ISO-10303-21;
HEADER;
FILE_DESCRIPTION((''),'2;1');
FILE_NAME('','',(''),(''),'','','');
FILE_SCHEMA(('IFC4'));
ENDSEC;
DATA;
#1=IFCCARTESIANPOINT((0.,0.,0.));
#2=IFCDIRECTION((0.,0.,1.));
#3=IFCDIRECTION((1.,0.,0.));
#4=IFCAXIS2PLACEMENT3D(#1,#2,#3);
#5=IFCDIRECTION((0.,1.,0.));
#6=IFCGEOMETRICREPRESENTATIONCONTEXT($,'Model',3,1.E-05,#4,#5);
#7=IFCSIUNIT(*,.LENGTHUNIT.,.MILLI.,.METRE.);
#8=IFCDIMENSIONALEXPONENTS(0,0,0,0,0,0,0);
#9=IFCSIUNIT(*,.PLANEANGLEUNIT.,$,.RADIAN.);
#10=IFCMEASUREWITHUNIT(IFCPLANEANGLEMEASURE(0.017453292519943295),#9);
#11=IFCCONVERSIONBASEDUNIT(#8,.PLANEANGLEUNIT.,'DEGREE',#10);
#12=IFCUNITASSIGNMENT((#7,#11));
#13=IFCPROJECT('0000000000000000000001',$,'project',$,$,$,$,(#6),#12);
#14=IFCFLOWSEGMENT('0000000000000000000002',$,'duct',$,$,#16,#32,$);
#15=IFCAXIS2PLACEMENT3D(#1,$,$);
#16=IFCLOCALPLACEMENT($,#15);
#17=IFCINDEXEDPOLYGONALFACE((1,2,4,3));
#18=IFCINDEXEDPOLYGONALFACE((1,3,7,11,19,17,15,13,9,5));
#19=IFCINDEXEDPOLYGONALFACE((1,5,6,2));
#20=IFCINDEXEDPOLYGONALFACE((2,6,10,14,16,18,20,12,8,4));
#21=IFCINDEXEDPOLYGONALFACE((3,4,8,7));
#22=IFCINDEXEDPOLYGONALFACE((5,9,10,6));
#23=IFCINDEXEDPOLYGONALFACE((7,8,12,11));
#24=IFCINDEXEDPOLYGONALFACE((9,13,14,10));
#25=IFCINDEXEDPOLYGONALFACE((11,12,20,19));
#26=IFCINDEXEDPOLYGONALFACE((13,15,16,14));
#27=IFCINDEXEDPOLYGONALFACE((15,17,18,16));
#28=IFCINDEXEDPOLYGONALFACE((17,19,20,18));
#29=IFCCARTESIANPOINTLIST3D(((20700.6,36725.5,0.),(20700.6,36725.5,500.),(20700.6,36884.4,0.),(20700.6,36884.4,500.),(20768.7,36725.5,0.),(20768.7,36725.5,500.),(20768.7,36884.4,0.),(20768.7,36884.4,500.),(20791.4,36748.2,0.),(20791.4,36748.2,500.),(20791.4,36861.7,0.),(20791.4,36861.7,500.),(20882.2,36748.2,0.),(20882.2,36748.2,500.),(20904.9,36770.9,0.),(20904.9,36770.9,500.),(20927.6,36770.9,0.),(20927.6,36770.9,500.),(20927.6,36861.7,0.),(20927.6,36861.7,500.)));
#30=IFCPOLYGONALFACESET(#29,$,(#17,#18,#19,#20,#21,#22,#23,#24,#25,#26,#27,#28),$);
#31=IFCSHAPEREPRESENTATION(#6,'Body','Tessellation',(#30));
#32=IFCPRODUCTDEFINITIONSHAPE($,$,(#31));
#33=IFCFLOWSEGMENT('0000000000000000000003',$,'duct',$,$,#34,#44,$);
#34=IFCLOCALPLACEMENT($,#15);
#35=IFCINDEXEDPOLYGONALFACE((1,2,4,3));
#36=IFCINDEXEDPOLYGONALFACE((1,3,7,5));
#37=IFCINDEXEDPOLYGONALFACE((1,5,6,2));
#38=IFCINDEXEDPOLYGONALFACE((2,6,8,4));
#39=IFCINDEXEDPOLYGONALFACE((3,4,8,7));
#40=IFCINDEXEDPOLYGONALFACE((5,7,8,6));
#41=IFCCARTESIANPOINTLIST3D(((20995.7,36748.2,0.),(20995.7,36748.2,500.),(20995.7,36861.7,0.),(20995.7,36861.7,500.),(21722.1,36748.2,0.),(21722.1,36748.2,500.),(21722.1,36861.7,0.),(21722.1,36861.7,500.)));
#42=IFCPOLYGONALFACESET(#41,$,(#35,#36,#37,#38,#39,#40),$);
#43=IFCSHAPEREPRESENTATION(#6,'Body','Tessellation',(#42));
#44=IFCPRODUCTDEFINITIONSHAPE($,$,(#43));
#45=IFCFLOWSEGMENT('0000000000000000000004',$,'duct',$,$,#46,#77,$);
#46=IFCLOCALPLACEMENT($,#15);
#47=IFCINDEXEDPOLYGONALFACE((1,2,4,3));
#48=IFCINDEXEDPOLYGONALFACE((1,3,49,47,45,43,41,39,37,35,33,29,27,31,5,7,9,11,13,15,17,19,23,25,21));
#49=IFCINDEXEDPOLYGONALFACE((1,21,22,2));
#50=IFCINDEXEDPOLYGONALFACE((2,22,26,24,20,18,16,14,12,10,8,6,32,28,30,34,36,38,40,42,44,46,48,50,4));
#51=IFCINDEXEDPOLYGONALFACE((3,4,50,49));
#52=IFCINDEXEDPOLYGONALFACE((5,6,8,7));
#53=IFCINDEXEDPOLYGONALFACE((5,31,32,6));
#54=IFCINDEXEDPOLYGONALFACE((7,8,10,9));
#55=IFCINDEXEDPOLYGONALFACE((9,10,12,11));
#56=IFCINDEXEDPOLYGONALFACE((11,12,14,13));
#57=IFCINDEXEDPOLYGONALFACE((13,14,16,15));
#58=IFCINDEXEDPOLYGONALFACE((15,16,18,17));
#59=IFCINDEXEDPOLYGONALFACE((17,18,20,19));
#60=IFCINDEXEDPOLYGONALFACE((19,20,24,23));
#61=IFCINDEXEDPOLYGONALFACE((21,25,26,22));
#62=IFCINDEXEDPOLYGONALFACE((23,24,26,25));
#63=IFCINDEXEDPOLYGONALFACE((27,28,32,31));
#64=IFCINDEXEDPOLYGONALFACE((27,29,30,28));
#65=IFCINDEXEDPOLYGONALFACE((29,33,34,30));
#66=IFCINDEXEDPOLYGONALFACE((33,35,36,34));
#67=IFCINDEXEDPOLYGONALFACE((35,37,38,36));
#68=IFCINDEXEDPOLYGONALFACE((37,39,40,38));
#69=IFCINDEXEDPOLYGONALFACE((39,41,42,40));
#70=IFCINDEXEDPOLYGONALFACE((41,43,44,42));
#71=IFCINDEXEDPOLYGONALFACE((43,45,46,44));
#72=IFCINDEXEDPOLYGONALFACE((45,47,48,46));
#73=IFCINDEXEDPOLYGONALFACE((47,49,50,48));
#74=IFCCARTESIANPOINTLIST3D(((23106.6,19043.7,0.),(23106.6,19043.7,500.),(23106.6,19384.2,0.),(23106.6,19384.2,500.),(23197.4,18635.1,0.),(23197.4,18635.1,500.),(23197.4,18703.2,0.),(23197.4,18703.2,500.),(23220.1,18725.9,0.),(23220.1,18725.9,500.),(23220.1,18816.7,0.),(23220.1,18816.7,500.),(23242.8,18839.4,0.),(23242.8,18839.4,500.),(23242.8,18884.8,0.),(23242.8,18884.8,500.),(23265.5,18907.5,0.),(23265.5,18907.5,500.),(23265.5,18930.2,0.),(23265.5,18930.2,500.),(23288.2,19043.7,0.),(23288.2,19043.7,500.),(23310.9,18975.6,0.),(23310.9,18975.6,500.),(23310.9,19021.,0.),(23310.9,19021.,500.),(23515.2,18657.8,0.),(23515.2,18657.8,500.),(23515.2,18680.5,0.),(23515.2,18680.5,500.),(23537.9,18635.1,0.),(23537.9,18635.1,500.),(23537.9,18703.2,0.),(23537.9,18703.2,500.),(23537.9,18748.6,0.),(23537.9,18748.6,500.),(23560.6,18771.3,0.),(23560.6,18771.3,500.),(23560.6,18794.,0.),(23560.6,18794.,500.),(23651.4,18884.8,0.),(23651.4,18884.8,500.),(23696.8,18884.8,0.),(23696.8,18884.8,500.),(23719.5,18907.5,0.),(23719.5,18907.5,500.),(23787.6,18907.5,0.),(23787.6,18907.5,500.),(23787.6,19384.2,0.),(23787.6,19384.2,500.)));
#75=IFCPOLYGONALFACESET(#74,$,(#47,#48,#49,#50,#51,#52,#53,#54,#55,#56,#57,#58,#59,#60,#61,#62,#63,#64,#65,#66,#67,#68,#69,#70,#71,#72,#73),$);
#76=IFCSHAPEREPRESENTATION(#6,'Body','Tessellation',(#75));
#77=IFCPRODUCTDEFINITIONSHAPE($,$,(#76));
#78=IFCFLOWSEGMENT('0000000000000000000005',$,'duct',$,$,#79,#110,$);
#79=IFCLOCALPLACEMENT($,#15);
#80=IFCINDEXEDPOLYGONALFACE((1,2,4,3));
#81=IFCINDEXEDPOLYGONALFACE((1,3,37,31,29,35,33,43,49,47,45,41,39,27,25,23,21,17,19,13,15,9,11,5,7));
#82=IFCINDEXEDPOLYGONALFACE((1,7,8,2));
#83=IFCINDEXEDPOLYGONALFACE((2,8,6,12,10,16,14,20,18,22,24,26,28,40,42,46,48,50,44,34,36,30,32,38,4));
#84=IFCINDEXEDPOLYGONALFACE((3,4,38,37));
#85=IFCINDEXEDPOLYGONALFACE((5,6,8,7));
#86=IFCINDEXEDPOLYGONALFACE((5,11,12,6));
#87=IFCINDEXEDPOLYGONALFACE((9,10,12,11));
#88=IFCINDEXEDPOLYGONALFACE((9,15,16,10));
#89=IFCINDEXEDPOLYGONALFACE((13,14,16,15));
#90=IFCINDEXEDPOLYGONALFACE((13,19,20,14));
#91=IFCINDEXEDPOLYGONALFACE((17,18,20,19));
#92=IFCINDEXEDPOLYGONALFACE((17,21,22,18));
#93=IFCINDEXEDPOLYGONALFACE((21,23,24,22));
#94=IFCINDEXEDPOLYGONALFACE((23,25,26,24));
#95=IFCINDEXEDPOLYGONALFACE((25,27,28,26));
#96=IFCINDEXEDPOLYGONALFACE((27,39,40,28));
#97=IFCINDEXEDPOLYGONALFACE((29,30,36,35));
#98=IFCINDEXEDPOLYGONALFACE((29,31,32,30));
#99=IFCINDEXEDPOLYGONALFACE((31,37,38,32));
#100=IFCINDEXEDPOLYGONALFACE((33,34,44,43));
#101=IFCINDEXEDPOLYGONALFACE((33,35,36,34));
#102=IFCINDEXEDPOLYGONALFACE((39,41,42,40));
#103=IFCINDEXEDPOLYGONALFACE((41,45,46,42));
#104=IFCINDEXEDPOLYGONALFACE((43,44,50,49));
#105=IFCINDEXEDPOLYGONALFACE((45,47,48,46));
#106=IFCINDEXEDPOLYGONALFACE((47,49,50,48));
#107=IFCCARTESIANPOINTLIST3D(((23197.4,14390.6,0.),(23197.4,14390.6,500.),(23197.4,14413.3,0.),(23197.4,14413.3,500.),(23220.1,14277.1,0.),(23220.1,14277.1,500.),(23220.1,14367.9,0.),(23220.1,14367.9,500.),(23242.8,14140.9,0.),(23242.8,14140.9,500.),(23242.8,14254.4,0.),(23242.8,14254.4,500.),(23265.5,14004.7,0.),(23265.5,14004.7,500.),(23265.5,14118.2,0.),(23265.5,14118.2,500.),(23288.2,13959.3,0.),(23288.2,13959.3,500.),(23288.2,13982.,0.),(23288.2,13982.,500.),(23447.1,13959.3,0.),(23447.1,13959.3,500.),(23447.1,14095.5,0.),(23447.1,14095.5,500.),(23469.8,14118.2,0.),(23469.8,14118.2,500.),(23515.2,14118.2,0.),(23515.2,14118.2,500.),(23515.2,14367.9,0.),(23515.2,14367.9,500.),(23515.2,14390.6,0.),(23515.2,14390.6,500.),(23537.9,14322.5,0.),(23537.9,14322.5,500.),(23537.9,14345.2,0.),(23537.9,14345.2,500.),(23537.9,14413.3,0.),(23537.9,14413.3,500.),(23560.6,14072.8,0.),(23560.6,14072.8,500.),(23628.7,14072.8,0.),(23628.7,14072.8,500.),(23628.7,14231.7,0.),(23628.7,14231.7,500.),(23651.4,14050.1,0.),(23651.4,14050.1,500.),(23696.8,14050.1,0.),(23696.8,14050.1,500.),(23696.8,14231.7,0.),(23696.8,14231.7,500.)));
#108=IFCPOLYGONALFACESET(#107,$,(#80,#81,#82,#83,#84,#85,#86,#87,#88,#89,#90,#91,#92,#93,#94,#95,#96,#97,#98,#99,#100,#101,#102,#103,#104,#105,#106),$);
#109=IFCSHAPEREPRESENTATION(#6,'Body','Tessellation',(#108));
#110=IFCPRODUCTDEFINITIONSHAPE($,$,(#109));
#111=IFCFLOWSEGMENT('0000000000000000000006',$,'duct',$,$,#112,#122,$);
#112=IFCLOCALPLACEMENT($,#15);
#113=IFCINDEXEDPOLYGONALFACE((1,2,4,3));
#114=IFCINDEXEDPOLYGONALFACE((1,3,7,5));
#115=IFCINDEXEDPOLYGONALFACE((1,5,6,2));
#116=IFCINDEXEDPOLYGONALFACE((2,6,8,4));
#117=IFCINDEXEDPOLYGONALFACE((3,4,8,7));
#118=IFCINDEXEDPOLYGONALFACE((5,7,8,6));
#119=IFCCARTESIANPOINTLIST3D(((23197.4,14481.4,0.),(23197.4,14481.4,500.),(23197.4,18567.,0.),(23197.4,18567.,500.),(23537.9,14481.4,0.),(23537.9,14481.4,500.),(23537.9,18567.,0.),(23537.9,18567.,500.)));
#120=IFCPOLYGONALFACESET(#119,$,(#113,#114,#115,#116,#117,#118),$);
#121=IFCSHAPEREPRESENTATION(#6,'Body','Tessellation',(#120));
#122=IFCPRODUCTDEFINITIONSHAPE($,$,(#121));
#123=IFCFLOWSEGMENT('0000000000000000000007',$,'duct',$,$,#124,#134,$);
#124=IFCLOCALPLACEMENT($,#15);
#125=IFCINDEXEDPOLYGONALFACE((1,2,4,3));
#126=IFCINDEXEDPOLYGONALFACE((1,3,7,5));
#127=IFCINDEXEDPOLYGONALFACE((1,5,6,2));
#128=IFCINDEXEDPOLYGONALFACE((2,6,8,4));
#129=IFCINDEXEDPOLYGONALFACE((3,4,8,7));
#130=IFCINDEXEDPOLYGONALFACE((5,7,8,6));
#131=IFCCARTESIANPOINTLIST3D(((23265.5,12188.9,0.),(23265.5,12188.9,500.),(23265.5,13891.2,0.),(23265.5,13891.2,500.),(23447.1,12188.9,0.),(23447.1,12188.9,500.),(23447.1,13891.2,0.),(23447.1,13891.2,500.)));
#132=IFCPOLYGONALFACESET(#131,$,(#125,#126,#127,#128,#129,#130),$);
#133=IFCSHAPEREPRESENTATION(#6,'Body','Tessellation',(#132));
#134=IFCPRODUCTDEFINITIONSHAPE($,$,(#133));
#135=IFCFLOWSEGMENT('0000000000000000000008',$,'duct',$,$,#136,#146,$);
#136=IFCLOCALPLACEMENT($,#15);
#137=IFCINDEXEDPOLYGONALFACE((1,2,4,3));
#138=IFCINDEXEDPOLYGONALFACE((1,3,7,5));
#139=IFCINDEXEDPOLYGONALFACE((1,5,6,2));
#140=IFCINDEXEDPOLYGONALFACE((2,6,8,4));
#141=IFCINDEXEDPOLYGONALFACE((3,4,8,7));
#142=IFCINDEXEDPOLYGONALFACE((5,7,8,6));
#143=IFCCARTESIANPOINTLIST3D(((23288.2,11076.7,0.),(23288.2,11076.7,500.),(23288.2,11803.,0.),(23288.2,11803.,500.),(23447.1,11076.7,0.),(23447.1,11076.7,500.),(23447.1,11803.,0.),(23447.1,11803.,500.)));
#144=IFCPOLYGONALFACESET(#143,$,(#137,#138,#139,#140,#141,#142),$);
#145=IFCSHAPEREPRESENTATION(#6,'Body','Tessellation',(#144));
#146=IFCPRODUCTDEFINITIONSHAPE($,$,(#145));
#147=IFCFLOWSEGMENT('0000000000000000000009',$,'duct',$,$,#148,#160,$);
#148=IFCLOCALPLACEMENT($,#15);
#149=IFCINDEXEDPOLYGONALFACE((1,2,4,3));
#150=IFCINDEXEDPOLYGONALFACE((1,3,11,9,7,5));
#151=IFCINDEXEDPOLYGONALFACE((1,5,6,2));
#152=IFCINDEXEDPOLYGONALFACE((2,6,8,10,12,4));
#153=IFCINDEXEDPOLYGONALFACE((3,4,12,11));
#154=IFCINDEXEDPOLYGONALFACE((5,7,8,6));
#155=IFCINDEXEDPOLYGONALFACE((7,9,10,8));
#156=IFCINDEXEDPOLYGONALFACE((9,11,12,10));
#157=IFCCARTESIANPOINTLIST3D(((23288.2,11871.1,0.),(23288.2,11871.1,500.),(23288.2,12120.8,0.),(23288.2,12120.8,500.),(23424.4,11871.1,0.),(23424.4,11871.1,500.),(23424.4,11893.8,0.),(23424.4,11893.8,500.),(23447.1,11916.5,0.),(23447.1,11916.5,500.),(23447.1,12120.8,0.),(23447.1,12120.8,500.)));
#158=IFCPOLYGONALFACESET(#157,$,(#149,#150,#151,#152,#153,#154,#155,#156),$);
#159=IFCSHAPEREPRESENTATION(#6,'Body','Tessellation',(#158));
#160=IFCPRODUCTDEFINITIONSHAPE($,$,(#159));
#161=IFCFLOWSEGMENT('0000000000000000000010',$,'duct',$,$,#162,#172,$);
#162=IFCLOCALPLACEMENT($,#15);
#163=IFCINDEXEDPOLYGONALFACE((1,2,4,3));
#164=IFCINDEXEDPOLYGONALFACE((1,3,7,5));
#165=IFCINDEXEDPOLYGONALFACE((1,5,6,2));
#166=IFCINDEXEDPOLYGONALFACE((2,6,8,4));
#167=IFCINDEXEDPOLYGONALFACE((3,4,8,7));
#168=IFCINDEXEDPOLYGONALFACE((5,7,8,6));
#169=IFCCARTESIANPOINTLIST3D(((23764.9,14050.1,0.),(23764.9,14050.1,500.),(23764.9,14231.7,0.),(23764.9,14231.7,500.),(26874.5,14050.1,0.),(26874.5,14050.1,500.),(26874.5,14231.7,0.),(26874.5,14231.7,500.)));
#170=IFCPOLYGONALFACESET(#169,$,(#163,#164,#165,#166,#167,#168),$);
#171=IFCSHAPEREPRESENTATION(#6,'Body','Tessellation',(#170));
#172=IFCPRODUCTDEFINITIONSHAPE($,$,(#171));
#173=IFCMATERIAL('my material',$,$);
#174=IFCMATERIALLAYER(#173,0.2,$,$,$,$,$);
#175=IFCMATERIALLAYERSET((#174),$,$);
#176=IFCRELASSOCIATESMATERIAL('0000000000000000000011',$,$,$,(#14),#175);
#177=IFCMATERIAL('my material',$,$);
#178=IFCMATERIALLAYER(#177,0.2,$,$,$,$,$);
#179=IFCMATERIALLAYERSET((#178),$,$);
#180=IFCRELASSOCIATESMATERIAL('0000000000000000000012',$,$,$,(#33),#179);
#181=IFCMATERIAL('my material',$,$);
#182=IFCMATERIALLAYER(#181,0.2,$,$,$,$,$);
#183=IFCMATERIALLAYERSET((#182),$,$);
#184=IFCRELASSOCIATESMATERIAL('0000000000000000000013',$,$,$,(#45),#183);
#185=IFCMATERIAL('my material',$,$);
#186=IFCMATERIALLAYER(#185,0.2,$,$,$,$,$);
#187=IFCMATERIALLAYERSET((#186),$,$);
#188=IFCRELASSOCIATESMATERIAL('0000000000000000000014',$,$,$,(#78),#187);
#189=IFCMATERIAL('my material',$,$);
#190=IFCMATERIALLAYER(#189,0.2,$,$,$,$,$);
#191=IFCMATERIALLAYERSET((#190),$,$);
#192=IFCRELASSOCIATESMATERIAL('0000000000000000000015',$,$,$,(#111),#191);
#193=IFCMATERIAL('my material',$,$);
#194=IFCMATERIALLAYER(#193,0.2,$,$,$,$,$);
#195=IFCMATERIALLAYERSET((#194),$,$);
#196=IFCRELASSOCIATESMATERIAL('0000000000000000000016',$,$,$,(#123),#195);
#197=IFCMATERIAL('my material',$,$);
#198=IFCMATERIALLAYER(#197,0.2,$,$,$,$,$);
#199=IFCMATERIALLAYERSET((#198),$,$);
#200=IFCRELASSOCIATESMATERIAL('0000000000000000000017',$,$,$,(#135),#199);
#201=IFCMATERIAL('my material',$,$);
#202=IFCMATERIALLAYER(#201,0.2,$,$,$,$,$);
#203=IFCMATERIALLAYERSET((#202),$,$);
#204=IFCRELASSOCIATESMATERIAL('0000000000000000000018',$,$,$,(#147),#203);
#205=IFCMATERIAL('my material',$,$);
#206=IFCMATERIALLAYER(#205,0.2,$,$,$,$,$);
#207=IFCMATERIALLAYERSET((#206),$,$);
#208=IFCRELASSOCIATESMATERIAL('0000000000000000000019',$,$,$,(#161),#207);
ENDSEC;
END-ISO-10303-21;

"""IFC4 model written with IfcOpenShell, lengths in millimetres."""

from ifc_helpers import new_model, entity, si_unit, converted_unit, direction, origin_with_axes, place, context, project, polyline, outline, extrude, material, layer, layer_set, layer_usage, element, save


model = new_model("IFC4")

# Units and contexts
model_context = context("Model", 3, precision=1e-05, world=origin_with_axes(), true_north=direction((0.0, 1.0, 0.0)))
ifc_project = project(units=[si_unit("LENGTHUNIT", "METRE", prefix="MILLI"), converted_unit("PLANEANGLEUNIT", "DEGREE", entity("IfcPlaneAngleMeasure", 0.017453292519943295), si_unit("PLANEANGLEUNIT", "RADIAN"), dimensions=[0, 0, 0, 0, 0, 0, 0])], contexts=[model_context])

# Flow segments
ifc_material_1 = material(Name="my material")
ifc_layer_1 = layer(ifc_material_1, 0.2)
ifc_layer_set_1 = layer_set([ifc_layer_1])
ifc_layer_usage_1 = layer_usage(ifc_layer_set_1, "AXIS2", "POSITIVE", -0.1)
flow_segment_1_placement = place(None, origin_with_axes())
element("IfcFlowSegment", 1, at=flow_segment_1_placement, material=ifc_layer_usage_1, Name="duct", context=model_context, shape_type="SweptSolid", body=[
    extrude(outline(polyline([(20700.6, 36725.5), (20768.7, 36725.5), (20791.4, 36748.2), (20882.2, 36748.2), (20904.9, 36770.9), (20927.6, 36770.9), (20927.6, 36861.7), (20791.4, 36861.7), (20768.7, 36884.4), (20700.6, 36884.4), (20700.6, 36725.5)])), origin_with_axes(), (0.0, 0.0, 1.0), 500.0),
])
ifc_material_2 = material(Name="my material")
ifc_layer_2 = layer(ifc_material_2, 0.2)
ifc_layer_set_2 = layer_set([ifc_layer_2])
ifc_layer_usage_2 = layer_usage(ifc_layer_set_2, "AXIS2", "POSITIVE", -0.1)
flow_segment_2_placement = place(None, origin_with_axes())
element("IfcFlowSegment", 2, at=flow_segment_2_placement, material=ifc_layer_usage_2, Name="duct", context=model_context, shape_type="SweptSolid", body=[
    extrude(outline(polyline([(20995.7, 36748.2), (21722.1, 36748.2), (21722.1, 36861.7), (20995.7, 36861.7), (20995.7, 36748.2)])), origin_with_axes(), (0.0, 0.0, 1.0), 500.0),
])
ifc_material_3 = material(Name="my material")
ifc_layer_3 = layer(ifc_material_3, 0.2)
ifc_layer_set_3 = layer_set([ifc_layer_3])
ifc_layer_usage_3 = layer_usage(ifc_layer_set_3, "AXIS2", "POSITIVE", -0.1)
flow_segment_3_placement = place(None, origin_with_axes())
element("IfcFlowSegment", 3, at=flow_segment_3_placement, material=ifc_layer_usage_3, Name="duct", context=model_context, shape_type="SweptSolid", body=[
    extrude(outline(polyline([(23106.6, 19043.7), (23288.2, 19043.7), (23310.9, 19021.0), (23310.9, 18975.6), (23265.5, 18930.2), (23265.5, 18907.5), (23242.8, 18884.8), (23242.8, 18839.4), (23220.1, 18816.7), (23220.1, 18725.9), (23197.4, 18703.2), (23197.4, 18635.1), (23537.9, 18635.1), (23515.2, 18657.8), (23515.2, 18680.5), (23537.9, 18703.2), (23537.9, 18748.6), (23560.6, 18771.3), (23560.6, 18794.0), (23651.4, 18884.8), (23696.8, 18884.8), (23719.5, 18907.5), (23787.6, 18907.5), (23787.6, 19384.2), (23106.6, 19384.2), (23106.6, 19043.7)])), origin_with_axes(), (0.0, 0.0, 1.0), 500.0),
])
ifc_material_4 = material(Name="my material")
ifc_layer_4 = layer(ifc_material_4, 0.2)
ifc_layer_set_4 = layer_set([ifc_layer_4])
ifc_layer_usage_4 = layer_usage(ifc_layer_set_4, "AXIS2", "POSITIVE", -0.1)
flow_segment_4_placement = place(None, origin_with_axes())
element("IfcFlowSegment", 4, at=flow_segment_4_placement, material=ifc_layer_usage_4, Name="duct", context=model_context, shape_type="SweptSolid", body=[
    extrude(outline(polyline([(23197.4, 14390.6), (23220.1, 14367.9), (23220.1, 14277.1), (23242.8, 14254.4), (23242.8, 14140.9), (23265.5, 14118.2), (23265.5, 14004.7), (23288.2, 13982.0), (23288.2, 13959.3), (23447.1, 13959.3), (23447.1, 14095.5), (23469.8, 14118.2), (23515.2, 14118.2), (23560.6, 14072.8), (23628.7, 14072.8), (23651.4, 14050.1), (23696.8, 14050.1), (23696.8, 14231.7), (23628.7, 14231.7), (23537.9, 14322.5), (23537.9, 14345.2), (23515.2, 14367.9), (23515.2, 14390.6), (23537.9, 14413.3), (23197.4, 14413.3), (23197.4, 14390.6)])), origin_with_axes(), (0.0, 0.0, 1.0), 500.0),
])
ifc_material_5 = material(Name="my material")
ifc_layer_5 = layer(ifc_material_5, 0.2)
ifc_layer_set_5 = layer_set([ifc_layer_5])
ifc_layer_usage_5 = layer_usage(ifc_layer_set_5, "AXIS2", "POSITIVE", -0.1)
flow_segment_5_placement = place(None, origin_with_axes())
element("IfcFlowSegment", 5, at=flow_segment_5_placement, material=ifc_layer_usage_5, Name="duct", context=model_context, shape_type="SweptSolid", body=[
    extrude(outline(polyline([(23197.4, 14481.4), (23537.9, 14481.4), (23537.9, 18567.0), (23197.4, 18567.0), (23197.4, 14481.4)])), origin_with_axes(), (0.0, 0.0, 1.0), 500.0),
])
ifc_material_6 = material(Name="my material")
ifc_layer_6 = layer(ifc_material_6, 0.2)
ifc_layer_set_6 = layer_set([ifc_layer_6])
ifc_layer_usage_6 = layer_usage(ifc_layer_set_6, "AXIS2", "POSITIVE", -0.1)
flow_segment_6_placement = place(None, origin_with_axes())
element("IfcFlowSegment", 6, at=flow_segment_6_placement, material=ifc_layer_usage_6, Name="duct", context=model_context, shape_type="SweptSolid", body=[
    extrude(outline(polyline([(23265.5, 12188.9), (23447.1, 12188.9), (23447.1, 13891.2), (23265.5, 13891.2), (23265.5, 12188.9)])), origin_with_axes(), (0.0, 0.0, 1.0), 500.0),
])
ifc_material_7 = material(Name="my material")
ifc_layer_7 = layer(ifc_material_7, 0.2)
ifc_layer_set_7 = layer_set([ifc_layer_7])
ifc_layer_usage_7 = layer_usage(ifc_layer_set_7, "AXIS2", "POSITIVE", -0.1)
flow_segment_7_placement = place(None, origin_with_axes())
element("IfcFlowSegment", 7, at=flow_segment_7_placement, material=ifc_layer_usage_7, Name="duct", context=model_context, shape_type="SweptSolid", body=[
    extrude(outline(polyline([(23288.2, 11076.7), (23447.1, 11076.7), (23447.1, 11803.0), (23288.2, 11803.0), (23288.2, 11076.7)])), origin_with_axes(), (0.0, 0.0, 1.0), 500.0),
])
ifc_material_8 = material(Name="my material")
ifc_layer_8 = layer(ifc_material_8, 0.2)
ifc_layer_set_8 = layer_set([ifc_layer_8])
ifc_layer_usage_8 = layer_usage(ifc_layer_set_8, "AXIS2", "POSITIVE", -0.1)
flow_segment_8_placement = place(None, origin_with_axes())
element("IfcFlowSegment", 8, at=flow_segment_8_placement, material=ifc_layer_usage_8, Name="duct", context=model_context, shape_type="SweptSolid", body=[
    extrude(outline(polyline([(23288.2, 11871.1), (23424.4, 11871.1), (23424.4, 11893.8), (23447.1, 11916.5), (23447.1, 12120.8), (23288.2, 12120.8), (23288.2, 11871.1)])), origin_with_axes(), (0.0, 0.0, 1.0), 500.0),
])
ifc_material_9 = material(Name="my material")
ifc_layer_9 = layer(ifc_material_9, 0.2)
ifc_layer_set_9 = layer_set([ifc_layer_9])
ifc_layer_usage_9 = layer_usage(ifc_layer_set_9, "AXIS2", "POSITIVE", -0.1)
flow_segment_9_placement = place(None, origin_with_axes())
element("IfcFlowSegment", 9, at=flow_segment_9_placement, material=ifc_layer_usage_9, Name="duct", context=model_context, shape_type="SweptSolid", body=[
    extrude(outline(polyline([(23764.9, 14050.1), (26874.5, 14050.1), (26874.5, 14231.7), (23764.9, 14231.7), (23764.9, 14050.1)])), origin_with_axes(), (0.0, 0.0, 1.0), 500.0),
])

save(model, "model.ifc")
